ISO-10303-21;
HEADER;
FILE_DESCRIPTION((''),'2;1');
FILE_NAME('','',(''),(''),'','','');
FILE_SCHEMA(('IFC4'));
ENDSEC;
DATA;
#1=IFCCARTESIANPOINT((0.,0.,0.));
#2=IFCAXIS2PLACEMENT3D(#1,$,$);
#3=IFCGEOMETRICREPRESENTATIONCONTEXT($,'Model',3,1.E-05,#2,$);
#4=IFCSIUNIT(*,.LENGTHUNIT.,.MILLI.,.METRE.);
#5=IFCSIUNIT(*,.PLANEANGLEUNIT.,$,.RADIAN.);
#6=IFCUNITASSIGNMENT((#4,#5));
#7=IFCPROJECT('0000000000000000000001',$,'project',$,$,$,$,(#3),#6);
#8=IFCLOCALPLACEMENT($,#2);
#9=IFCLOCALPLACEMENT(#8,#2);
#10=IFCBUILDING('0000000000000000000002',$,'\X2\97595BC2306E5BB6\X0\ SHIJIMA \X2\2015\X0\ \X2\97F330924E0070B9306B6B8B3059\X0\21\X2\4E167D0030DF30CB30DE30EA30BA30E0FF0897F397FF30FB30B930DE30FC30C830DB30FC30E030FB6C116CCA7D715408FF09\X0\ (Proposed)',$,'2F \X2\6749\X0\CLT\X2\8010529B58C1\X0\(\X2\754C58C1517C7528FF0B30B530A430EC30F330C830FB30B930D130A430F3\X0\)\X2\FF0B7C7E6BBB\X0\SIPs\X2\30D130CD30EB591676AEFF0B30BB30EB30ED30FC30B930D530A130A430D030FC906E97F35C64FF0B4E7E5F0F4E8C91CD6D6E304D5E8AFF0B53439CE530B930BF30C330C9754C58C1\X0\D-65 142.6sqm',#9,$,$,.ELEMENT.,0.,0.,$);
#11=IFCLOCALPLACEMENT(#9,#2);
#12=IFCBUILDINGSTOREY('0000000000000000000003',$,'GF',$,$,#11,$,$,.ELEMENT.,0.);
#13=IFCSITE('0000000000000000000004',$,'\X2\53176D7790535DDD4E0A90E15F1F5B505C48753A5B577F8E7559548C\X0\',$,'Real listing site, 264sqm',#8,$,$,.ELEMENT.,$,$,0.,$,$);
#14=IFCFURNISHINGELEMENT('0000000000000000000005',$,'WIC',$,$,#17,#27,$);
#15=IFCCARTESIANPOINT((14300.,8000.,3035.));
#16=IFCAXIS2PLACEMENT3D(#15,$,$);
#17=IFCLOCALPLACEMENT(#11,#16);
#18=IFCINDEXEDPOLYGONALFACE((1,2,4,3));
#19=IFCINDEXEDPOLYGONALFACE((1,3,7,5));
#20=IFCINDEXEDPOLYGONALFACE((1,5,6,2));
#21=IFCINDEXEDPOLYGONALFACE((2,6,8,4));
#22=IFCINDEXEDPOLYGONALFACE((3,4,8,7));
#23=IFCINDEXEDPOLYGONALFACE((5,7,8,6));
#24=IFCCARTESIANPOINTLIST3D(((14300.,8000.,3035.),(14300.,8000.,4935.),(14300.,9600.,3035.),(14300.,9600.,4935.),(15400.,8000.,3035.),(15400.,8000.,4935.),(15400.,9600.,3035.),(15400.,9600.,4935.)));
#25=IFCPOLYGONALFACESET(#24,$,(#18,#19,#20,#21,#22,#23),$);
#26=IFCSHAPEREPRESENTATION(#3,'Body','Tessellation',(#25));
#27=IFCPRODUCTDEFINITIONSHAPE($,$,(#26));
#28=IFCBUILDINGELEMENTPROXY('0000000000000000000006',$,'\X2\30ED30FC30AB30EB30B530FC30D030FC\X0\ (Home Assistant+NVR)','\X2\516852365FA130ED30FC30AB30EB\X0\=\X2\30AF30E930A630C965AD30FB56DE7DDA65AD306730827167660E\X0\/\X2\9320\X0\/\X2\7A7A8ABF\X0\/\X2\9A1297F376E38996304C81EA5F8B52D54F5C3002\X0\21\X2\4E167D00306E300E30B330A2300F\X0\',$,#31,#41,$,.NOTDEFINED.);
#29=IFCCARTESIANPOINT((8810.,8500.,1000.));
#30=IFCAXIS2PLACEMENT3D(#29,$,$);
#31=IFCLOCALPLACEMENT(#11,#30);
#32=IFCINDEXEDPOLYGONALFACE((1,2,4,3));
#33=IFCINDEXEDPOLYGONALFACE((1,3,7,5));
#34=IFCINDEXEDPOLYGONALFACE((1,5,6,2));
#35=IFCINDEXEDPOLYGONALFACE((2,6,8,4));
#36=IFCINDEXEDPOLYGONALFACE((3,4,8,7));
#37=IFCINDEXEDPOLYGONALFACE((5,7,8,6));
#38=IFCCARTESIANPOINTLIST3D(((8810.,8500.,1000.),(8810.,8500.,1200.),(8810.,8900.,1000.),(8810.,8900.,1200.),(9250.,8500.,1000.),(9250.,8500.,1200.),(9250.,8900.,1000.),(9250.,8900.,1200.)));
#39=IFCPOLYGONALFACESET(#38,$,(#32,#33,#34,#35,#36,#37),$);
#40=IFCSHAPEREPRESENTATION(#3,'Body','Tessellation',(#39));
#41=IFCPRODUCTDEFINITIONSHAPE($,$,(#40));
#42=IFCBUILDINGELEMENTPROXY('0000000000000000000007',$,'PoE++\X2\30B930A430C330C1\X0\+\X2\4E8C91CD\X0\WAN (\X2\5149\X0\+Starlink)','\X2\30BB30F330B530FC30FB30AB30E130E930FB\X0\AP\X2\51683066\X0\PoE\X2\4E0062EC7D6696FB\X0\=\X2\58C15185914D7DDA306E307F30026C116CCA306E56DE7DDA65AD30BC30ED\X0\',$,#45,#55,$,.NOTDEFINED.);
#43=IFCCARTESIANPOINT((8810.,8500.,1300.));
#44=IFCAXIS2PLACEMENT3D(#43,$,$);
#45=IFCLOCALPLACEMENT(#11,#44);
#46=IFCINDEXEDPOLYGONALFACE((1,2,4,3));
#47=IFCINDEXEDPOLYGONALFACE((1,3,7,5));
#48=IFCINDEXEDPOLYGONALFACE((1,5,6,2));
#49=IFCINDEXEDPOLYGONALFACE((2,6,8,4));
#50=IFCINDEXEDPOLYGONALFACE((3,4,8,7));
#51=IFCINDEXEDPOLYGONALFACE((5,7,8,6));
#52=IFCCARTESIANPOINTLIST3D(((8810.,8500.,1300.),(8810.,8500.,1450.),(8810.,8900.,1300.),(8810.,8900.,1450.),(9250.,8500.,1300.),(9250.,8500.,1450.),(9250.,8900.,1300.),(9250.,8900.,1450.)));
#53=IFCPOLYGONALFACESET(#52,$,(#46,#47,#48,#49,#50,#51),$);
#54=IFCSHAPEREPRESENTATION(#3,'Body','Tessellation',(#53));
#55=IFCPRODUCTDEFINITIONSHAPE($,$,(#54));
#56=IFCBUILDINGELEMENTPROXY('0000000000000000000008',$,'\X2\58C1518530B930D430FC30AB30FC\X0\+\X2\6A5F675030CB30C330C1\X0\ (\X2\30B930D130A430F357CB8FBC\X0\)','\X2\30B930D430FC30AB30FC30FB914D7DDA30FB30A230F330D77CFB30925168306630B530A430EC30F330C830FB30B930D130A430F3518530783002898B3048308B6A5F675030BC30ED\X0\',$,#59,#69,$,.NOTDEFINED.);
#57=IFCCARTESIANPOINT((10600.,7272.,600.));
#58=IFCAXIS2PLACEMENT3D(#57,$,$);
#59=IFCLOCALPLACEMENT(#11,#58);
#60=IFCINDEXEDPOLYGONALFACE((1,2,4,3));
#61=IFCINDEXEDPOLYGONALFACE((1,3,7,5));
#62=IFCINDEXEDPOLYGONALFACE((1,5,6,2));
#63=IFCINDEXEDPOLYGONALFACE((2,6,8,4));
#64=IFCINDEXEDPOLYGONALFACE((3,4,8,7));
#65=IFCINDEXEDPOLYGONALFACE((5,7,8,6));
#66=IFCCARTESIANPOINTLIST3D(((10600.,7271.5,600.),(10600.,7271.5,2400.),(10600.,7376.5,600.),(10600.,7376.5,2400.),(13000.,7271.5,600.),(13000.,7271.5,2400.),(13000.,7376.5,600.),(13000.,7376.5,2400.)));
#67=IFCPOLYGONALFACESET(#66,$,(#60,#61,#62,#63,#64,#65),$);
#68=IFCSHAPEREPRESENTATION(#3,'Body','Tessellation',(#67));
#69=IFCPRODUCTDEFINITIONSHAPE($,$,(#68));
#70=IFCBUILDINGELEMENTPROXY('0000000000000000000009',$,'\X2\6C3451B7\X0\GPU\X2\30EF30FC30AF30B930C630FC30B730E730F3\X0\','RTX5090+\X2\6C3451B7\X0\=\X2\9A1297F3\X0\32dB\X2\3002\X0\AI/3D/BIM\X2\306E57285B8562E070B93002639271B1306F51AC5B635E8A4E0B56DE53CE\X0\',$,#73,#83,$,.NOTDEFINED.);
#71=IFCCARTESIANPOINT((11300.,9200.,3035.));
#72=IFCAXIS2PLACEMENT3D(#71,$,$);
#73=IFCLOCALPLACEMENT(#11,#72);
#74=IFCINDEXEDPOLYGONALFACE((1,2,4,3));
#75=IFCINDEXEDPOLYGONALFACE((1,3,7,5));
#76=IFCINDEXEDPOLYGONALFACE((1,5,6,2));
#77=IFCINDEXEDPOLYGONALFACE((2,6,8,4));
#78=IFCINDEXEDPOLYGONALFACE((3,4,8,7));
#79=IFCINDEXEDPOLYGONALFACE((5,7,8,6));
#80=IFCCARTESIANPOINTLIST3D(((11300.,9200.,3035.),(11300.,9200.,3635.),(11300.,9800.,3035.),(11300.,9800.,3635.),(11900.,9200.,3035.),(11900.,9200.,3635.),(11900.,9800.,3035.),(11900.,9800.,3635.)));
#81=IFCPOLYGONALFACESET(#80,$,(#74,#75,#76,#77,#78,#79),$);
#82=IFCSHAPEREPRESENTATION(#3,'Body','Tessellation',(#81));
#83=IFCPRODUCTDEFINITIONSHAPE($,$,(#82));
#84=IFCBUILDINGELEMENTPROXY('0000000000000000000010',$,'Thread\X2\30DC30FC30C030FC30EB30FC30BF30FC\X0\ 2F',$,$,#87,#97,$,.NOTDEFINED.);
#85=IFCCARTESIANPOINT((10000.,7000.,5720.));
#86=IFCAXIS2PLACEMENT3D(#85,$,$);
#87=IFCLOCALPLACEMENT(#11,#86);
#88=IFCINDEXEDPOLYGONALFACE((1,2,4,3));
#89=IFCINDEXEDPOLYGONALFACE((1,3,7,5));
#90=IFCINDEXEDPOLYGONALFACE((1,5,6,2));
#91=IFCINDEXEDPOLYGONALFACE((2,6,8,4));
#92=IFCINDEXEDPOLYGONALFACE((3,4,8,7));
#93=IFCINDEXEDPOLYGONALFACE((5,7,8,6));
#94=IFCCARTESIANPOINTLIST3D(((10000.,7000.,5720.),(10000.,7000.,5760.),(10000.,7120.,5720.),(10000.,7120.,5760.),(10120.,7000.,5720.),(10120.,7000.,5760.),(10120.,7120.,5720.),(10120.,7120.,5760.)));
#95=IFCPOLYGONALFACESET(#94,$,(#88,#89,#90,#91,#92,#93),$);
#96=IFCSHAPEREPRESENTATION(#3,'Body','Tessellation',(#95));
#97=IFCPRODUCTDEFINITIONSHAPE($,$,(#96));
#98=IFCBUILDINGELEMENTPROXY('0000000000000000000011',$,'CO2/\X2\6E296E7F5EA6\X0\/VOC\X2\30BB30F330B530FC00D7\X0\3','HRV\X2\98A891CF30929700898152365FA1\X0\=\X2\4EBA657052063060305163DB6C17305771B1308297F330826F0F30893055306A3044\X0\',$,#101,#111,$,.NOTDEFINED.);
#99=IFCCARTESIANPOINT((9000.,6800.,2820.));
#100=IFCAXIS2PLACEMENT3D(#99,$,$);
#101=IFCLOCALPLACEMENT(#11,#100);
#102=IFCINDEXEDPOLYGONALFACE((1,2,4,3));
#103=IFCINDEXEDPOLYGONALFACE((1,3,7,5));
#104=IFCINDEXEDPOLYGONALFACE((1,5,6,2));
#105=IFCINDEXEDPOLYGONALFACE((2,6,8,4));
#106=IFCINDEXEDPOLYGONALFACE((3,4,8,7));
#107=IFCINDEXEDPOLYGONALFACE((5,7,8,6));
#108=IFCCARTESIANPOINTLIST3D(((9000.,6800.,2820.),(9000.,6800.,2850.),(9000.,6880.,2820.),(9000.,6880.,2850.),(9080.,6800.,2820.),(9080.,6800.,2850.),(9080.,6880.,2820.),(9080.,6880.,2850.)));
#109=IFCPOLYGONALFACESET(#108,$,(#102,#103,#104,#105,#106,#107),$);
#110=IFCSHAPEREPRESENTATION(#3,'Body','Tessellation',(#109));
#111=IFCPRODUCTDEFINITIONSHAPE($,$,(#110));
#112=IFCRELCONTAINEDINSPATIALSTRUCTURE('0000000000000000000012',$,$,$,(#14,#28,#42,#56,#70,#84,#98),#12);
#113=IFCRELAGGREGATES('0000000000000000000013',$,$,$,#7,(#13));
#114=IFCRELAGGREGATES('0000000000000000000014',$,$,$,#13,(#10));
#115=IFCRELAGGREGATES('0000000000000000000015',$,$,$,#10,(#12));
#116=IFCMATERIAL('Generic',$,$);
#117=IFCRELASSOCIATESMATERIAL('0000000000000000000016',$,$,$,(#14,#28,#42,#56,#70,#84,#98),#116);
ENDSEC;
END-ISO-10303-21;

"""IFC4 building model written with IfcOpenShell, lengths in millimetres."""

from ifc_helpers import new_model, si_unit, frame, frame_2d, origin, place, context, project, spatial, rectangle, extrude, material, element, save


model = new_model("IFC4")

# Units and contexts
model_context = context("Model", 3, precision=1e-05, world=origin())
ifc_project = project(units=[si_unit("LENGTHUNIT", "METRE", prefix="MILLI"), si_unit("PLANEANGLEUNIT", "RADIAN")], contexts=[model_context])

# Site, building, storey
site_placement = place(None, origin())
site = spatial("IfcSite", under=ifc_project, at=site_placement, Name="北海道川上郡弟子屈町字美留和", ObjectType="Real listing site, 264sqm", CompositionType="ELEMENT", RefElevation=0.0)
building_placement = place(site_placement, origin())
building = spatial("IfcBuilding", under=site, at=building_placement, Name="静寂の家 SHIJIMA ― 音を一点に残す21世紀ミニマリズム（音響・スマートホーム・民泊統合） (Proposed)", ObjectType="2F 杉CLT耐力壁(界壁兼用＋サイレント・スパイン)＋籾殻SIPsパネル外皮＋セルロースファイバー遮音層＋乾式二重浮き床＋千鳥スタッド界壁D-65 142.6sqm", CompositionType="ELEMENT", ElevationOfRefHeight=0.0, ElevationOfTerrain=0.0)
storey_placement = place(building_placement, origin())
storey = spatial("IfcBuildingStorey", under=building, at=storey_placement, Name="GF", CompositionType="ELEMENT", Elevation=0.0)

# Shared definitions
ifc_material = material(Name="Generic")

# Furnishing element
furnishing_1_placement = place(storey_placement, frame((14300.0, 8000.0, 3035.0)))
element("IfcFurnishingElement", 1, at=furnishing_1_placement, inside=storey, material=ifc_material, Name="WIC", context=model_context, shape_type="SweptSolid", body=[
    extrude(rectangle(XDim=1100.0, YDim=1600.0, at=frame_2d((550.0, 800.0))), frame((14300.0, 8000.0, 3035.0)), (0.0, 0.0, 1.0), 1900.0),
])

# Building element proxies
proxy_1_placement = place(storey_placement, frame((8810.0, 8500.0, 1000.0)))
element("IfcBuildingElementProxy", 2, at=proxy_1_placement, inside=storey, material=ifc_material, Name="ローカルサーバー (Home Assistant+NVR)", Description="全制御ローカル=クラウド断・回線断でも照明/錠/空調/騒音監視が自律動作。21世紀の『コア』", PredefinedType="NOTDEFINED", context=model_context, shape_type="SweptSolid", body=[
    extrude(rectangle(XDim=440.0, YDim=400.0, at=frame_2d((220.0, 200.0))), frame((8810.0, 8500.0, 1000.0)), (0.0, 0.0, 1.0), 200.0),
])
proxy_2_placement = place(storey_placement, frame((8810.0, 8500.0, 1300.0)))
element("IfcBuildingElementProxy", 3, at=proxy_2_placement, inside=storey, material=ifc_material, Name="PoE++スイッチ+二重WAN (光+Starlink)", Description="センサー・カメラ・AP全てPoE一括給電=壁内配線のみ。民泊の回線断ゼロ", PredefinedType="NOTDEFINED", context=model_context, shape_type="SweptSolid", body=[
    extrude(rectangle(XDim=440.0, YDim=400.0, at=frame_2d((220.0, 200.0))), frame((8810.0, 8500.0, 1300.0)), (0.0, 0.0, 1.0), 150.0),
])
proxy_3_placement = place(storey_placement, frame((10600.0, 7272.0, 600.0)))
element("IfcBuildingElementProxy", 4, at=proxy_3_placement, inside=storey, material=ifc_material, Name="壁内スピーカー+機材ニッチ (スパイン埋込)", Description="スピーカー・配線・アンプ系を全てサイレント・スパイン内へ。見える機材ゼロ", PredefinedType="NOTDEFINED", context=model_context, shape_type="SweptSolid", body=[
    extrude(rectangle(XDim=2400.0, YDim=105.0, at=frame_2d((1200.0, 52.0))), frame((10600.0, 7272.0, 600.0)), (0.0, 0.0, 1.0), 1800.0),
])
proxy_4_placement = place(storey_placement, frame((11300.0, 9200.0, 3035.0)))
element("IfcBuildingElementProxy", 5, at=proxy_4_placement, inside=storey, material=ifc_material, Name="水冷GPUワークステーション", Description="RTX5090+水冷=騒音32dB。AI/3D/BIMの在宅拠点。排熱は冬季床下回収", PredefinedType="NOTDEFINED", context=model_context, shape_type="SweptSolid", body=[
    extrude(rectangle(XDim=600.0, YDim=600.0, at=frame_2d((300.0, 300.0))), frame((11300.0, 9200.0, 3035.0)), (0.0, 0.0, 1.0), 600.0),
])
proxy_5_placement = place(storey_placement, frame((10000.0, 7000.0, 5720.0)))
element("IfcBuildingElementProxy", 6, at=proxy_5_placement, inside=storey, material=ifc_material, Name="Threadボーダールーター 2F", PredefinedType="NOTDEFINED", context=model_context, shape_type="SweptSolid", body=[
    extrude(rectangle(XDim=120.0, YDim=120.0, at=frame_2d((60.0, 60.0))), frame((10000.0, 7000.0, 5720.0)), (0.0, 0.0, 1.0), 40.0),
])
proxy_6_placement = place(storey_placement, frame((9000.0, 6800.0, 2820.0)))
element("IfcBuildingElementProxy", 7, at=proxy_6_placement, inside=storey, material=ifc_material, Name="CO2/温湿度/VOCセンサー×3", Description="HRV風量を需要制御=人数分だけ換気し熱も音も漏らさない", PredefinedType="NOTDEFINED", context=model_context, shape_type="SweptSolid", body=[
    extrude(rectangle(XDim=80.0, YDim=80.0, at=frame_2d((40.0, 40.0))), frame((9000.0, 6800.0, 2820.0)), (0.0, 0.0, 1.0), 30.0),
])

save(model, "model.ifc")
